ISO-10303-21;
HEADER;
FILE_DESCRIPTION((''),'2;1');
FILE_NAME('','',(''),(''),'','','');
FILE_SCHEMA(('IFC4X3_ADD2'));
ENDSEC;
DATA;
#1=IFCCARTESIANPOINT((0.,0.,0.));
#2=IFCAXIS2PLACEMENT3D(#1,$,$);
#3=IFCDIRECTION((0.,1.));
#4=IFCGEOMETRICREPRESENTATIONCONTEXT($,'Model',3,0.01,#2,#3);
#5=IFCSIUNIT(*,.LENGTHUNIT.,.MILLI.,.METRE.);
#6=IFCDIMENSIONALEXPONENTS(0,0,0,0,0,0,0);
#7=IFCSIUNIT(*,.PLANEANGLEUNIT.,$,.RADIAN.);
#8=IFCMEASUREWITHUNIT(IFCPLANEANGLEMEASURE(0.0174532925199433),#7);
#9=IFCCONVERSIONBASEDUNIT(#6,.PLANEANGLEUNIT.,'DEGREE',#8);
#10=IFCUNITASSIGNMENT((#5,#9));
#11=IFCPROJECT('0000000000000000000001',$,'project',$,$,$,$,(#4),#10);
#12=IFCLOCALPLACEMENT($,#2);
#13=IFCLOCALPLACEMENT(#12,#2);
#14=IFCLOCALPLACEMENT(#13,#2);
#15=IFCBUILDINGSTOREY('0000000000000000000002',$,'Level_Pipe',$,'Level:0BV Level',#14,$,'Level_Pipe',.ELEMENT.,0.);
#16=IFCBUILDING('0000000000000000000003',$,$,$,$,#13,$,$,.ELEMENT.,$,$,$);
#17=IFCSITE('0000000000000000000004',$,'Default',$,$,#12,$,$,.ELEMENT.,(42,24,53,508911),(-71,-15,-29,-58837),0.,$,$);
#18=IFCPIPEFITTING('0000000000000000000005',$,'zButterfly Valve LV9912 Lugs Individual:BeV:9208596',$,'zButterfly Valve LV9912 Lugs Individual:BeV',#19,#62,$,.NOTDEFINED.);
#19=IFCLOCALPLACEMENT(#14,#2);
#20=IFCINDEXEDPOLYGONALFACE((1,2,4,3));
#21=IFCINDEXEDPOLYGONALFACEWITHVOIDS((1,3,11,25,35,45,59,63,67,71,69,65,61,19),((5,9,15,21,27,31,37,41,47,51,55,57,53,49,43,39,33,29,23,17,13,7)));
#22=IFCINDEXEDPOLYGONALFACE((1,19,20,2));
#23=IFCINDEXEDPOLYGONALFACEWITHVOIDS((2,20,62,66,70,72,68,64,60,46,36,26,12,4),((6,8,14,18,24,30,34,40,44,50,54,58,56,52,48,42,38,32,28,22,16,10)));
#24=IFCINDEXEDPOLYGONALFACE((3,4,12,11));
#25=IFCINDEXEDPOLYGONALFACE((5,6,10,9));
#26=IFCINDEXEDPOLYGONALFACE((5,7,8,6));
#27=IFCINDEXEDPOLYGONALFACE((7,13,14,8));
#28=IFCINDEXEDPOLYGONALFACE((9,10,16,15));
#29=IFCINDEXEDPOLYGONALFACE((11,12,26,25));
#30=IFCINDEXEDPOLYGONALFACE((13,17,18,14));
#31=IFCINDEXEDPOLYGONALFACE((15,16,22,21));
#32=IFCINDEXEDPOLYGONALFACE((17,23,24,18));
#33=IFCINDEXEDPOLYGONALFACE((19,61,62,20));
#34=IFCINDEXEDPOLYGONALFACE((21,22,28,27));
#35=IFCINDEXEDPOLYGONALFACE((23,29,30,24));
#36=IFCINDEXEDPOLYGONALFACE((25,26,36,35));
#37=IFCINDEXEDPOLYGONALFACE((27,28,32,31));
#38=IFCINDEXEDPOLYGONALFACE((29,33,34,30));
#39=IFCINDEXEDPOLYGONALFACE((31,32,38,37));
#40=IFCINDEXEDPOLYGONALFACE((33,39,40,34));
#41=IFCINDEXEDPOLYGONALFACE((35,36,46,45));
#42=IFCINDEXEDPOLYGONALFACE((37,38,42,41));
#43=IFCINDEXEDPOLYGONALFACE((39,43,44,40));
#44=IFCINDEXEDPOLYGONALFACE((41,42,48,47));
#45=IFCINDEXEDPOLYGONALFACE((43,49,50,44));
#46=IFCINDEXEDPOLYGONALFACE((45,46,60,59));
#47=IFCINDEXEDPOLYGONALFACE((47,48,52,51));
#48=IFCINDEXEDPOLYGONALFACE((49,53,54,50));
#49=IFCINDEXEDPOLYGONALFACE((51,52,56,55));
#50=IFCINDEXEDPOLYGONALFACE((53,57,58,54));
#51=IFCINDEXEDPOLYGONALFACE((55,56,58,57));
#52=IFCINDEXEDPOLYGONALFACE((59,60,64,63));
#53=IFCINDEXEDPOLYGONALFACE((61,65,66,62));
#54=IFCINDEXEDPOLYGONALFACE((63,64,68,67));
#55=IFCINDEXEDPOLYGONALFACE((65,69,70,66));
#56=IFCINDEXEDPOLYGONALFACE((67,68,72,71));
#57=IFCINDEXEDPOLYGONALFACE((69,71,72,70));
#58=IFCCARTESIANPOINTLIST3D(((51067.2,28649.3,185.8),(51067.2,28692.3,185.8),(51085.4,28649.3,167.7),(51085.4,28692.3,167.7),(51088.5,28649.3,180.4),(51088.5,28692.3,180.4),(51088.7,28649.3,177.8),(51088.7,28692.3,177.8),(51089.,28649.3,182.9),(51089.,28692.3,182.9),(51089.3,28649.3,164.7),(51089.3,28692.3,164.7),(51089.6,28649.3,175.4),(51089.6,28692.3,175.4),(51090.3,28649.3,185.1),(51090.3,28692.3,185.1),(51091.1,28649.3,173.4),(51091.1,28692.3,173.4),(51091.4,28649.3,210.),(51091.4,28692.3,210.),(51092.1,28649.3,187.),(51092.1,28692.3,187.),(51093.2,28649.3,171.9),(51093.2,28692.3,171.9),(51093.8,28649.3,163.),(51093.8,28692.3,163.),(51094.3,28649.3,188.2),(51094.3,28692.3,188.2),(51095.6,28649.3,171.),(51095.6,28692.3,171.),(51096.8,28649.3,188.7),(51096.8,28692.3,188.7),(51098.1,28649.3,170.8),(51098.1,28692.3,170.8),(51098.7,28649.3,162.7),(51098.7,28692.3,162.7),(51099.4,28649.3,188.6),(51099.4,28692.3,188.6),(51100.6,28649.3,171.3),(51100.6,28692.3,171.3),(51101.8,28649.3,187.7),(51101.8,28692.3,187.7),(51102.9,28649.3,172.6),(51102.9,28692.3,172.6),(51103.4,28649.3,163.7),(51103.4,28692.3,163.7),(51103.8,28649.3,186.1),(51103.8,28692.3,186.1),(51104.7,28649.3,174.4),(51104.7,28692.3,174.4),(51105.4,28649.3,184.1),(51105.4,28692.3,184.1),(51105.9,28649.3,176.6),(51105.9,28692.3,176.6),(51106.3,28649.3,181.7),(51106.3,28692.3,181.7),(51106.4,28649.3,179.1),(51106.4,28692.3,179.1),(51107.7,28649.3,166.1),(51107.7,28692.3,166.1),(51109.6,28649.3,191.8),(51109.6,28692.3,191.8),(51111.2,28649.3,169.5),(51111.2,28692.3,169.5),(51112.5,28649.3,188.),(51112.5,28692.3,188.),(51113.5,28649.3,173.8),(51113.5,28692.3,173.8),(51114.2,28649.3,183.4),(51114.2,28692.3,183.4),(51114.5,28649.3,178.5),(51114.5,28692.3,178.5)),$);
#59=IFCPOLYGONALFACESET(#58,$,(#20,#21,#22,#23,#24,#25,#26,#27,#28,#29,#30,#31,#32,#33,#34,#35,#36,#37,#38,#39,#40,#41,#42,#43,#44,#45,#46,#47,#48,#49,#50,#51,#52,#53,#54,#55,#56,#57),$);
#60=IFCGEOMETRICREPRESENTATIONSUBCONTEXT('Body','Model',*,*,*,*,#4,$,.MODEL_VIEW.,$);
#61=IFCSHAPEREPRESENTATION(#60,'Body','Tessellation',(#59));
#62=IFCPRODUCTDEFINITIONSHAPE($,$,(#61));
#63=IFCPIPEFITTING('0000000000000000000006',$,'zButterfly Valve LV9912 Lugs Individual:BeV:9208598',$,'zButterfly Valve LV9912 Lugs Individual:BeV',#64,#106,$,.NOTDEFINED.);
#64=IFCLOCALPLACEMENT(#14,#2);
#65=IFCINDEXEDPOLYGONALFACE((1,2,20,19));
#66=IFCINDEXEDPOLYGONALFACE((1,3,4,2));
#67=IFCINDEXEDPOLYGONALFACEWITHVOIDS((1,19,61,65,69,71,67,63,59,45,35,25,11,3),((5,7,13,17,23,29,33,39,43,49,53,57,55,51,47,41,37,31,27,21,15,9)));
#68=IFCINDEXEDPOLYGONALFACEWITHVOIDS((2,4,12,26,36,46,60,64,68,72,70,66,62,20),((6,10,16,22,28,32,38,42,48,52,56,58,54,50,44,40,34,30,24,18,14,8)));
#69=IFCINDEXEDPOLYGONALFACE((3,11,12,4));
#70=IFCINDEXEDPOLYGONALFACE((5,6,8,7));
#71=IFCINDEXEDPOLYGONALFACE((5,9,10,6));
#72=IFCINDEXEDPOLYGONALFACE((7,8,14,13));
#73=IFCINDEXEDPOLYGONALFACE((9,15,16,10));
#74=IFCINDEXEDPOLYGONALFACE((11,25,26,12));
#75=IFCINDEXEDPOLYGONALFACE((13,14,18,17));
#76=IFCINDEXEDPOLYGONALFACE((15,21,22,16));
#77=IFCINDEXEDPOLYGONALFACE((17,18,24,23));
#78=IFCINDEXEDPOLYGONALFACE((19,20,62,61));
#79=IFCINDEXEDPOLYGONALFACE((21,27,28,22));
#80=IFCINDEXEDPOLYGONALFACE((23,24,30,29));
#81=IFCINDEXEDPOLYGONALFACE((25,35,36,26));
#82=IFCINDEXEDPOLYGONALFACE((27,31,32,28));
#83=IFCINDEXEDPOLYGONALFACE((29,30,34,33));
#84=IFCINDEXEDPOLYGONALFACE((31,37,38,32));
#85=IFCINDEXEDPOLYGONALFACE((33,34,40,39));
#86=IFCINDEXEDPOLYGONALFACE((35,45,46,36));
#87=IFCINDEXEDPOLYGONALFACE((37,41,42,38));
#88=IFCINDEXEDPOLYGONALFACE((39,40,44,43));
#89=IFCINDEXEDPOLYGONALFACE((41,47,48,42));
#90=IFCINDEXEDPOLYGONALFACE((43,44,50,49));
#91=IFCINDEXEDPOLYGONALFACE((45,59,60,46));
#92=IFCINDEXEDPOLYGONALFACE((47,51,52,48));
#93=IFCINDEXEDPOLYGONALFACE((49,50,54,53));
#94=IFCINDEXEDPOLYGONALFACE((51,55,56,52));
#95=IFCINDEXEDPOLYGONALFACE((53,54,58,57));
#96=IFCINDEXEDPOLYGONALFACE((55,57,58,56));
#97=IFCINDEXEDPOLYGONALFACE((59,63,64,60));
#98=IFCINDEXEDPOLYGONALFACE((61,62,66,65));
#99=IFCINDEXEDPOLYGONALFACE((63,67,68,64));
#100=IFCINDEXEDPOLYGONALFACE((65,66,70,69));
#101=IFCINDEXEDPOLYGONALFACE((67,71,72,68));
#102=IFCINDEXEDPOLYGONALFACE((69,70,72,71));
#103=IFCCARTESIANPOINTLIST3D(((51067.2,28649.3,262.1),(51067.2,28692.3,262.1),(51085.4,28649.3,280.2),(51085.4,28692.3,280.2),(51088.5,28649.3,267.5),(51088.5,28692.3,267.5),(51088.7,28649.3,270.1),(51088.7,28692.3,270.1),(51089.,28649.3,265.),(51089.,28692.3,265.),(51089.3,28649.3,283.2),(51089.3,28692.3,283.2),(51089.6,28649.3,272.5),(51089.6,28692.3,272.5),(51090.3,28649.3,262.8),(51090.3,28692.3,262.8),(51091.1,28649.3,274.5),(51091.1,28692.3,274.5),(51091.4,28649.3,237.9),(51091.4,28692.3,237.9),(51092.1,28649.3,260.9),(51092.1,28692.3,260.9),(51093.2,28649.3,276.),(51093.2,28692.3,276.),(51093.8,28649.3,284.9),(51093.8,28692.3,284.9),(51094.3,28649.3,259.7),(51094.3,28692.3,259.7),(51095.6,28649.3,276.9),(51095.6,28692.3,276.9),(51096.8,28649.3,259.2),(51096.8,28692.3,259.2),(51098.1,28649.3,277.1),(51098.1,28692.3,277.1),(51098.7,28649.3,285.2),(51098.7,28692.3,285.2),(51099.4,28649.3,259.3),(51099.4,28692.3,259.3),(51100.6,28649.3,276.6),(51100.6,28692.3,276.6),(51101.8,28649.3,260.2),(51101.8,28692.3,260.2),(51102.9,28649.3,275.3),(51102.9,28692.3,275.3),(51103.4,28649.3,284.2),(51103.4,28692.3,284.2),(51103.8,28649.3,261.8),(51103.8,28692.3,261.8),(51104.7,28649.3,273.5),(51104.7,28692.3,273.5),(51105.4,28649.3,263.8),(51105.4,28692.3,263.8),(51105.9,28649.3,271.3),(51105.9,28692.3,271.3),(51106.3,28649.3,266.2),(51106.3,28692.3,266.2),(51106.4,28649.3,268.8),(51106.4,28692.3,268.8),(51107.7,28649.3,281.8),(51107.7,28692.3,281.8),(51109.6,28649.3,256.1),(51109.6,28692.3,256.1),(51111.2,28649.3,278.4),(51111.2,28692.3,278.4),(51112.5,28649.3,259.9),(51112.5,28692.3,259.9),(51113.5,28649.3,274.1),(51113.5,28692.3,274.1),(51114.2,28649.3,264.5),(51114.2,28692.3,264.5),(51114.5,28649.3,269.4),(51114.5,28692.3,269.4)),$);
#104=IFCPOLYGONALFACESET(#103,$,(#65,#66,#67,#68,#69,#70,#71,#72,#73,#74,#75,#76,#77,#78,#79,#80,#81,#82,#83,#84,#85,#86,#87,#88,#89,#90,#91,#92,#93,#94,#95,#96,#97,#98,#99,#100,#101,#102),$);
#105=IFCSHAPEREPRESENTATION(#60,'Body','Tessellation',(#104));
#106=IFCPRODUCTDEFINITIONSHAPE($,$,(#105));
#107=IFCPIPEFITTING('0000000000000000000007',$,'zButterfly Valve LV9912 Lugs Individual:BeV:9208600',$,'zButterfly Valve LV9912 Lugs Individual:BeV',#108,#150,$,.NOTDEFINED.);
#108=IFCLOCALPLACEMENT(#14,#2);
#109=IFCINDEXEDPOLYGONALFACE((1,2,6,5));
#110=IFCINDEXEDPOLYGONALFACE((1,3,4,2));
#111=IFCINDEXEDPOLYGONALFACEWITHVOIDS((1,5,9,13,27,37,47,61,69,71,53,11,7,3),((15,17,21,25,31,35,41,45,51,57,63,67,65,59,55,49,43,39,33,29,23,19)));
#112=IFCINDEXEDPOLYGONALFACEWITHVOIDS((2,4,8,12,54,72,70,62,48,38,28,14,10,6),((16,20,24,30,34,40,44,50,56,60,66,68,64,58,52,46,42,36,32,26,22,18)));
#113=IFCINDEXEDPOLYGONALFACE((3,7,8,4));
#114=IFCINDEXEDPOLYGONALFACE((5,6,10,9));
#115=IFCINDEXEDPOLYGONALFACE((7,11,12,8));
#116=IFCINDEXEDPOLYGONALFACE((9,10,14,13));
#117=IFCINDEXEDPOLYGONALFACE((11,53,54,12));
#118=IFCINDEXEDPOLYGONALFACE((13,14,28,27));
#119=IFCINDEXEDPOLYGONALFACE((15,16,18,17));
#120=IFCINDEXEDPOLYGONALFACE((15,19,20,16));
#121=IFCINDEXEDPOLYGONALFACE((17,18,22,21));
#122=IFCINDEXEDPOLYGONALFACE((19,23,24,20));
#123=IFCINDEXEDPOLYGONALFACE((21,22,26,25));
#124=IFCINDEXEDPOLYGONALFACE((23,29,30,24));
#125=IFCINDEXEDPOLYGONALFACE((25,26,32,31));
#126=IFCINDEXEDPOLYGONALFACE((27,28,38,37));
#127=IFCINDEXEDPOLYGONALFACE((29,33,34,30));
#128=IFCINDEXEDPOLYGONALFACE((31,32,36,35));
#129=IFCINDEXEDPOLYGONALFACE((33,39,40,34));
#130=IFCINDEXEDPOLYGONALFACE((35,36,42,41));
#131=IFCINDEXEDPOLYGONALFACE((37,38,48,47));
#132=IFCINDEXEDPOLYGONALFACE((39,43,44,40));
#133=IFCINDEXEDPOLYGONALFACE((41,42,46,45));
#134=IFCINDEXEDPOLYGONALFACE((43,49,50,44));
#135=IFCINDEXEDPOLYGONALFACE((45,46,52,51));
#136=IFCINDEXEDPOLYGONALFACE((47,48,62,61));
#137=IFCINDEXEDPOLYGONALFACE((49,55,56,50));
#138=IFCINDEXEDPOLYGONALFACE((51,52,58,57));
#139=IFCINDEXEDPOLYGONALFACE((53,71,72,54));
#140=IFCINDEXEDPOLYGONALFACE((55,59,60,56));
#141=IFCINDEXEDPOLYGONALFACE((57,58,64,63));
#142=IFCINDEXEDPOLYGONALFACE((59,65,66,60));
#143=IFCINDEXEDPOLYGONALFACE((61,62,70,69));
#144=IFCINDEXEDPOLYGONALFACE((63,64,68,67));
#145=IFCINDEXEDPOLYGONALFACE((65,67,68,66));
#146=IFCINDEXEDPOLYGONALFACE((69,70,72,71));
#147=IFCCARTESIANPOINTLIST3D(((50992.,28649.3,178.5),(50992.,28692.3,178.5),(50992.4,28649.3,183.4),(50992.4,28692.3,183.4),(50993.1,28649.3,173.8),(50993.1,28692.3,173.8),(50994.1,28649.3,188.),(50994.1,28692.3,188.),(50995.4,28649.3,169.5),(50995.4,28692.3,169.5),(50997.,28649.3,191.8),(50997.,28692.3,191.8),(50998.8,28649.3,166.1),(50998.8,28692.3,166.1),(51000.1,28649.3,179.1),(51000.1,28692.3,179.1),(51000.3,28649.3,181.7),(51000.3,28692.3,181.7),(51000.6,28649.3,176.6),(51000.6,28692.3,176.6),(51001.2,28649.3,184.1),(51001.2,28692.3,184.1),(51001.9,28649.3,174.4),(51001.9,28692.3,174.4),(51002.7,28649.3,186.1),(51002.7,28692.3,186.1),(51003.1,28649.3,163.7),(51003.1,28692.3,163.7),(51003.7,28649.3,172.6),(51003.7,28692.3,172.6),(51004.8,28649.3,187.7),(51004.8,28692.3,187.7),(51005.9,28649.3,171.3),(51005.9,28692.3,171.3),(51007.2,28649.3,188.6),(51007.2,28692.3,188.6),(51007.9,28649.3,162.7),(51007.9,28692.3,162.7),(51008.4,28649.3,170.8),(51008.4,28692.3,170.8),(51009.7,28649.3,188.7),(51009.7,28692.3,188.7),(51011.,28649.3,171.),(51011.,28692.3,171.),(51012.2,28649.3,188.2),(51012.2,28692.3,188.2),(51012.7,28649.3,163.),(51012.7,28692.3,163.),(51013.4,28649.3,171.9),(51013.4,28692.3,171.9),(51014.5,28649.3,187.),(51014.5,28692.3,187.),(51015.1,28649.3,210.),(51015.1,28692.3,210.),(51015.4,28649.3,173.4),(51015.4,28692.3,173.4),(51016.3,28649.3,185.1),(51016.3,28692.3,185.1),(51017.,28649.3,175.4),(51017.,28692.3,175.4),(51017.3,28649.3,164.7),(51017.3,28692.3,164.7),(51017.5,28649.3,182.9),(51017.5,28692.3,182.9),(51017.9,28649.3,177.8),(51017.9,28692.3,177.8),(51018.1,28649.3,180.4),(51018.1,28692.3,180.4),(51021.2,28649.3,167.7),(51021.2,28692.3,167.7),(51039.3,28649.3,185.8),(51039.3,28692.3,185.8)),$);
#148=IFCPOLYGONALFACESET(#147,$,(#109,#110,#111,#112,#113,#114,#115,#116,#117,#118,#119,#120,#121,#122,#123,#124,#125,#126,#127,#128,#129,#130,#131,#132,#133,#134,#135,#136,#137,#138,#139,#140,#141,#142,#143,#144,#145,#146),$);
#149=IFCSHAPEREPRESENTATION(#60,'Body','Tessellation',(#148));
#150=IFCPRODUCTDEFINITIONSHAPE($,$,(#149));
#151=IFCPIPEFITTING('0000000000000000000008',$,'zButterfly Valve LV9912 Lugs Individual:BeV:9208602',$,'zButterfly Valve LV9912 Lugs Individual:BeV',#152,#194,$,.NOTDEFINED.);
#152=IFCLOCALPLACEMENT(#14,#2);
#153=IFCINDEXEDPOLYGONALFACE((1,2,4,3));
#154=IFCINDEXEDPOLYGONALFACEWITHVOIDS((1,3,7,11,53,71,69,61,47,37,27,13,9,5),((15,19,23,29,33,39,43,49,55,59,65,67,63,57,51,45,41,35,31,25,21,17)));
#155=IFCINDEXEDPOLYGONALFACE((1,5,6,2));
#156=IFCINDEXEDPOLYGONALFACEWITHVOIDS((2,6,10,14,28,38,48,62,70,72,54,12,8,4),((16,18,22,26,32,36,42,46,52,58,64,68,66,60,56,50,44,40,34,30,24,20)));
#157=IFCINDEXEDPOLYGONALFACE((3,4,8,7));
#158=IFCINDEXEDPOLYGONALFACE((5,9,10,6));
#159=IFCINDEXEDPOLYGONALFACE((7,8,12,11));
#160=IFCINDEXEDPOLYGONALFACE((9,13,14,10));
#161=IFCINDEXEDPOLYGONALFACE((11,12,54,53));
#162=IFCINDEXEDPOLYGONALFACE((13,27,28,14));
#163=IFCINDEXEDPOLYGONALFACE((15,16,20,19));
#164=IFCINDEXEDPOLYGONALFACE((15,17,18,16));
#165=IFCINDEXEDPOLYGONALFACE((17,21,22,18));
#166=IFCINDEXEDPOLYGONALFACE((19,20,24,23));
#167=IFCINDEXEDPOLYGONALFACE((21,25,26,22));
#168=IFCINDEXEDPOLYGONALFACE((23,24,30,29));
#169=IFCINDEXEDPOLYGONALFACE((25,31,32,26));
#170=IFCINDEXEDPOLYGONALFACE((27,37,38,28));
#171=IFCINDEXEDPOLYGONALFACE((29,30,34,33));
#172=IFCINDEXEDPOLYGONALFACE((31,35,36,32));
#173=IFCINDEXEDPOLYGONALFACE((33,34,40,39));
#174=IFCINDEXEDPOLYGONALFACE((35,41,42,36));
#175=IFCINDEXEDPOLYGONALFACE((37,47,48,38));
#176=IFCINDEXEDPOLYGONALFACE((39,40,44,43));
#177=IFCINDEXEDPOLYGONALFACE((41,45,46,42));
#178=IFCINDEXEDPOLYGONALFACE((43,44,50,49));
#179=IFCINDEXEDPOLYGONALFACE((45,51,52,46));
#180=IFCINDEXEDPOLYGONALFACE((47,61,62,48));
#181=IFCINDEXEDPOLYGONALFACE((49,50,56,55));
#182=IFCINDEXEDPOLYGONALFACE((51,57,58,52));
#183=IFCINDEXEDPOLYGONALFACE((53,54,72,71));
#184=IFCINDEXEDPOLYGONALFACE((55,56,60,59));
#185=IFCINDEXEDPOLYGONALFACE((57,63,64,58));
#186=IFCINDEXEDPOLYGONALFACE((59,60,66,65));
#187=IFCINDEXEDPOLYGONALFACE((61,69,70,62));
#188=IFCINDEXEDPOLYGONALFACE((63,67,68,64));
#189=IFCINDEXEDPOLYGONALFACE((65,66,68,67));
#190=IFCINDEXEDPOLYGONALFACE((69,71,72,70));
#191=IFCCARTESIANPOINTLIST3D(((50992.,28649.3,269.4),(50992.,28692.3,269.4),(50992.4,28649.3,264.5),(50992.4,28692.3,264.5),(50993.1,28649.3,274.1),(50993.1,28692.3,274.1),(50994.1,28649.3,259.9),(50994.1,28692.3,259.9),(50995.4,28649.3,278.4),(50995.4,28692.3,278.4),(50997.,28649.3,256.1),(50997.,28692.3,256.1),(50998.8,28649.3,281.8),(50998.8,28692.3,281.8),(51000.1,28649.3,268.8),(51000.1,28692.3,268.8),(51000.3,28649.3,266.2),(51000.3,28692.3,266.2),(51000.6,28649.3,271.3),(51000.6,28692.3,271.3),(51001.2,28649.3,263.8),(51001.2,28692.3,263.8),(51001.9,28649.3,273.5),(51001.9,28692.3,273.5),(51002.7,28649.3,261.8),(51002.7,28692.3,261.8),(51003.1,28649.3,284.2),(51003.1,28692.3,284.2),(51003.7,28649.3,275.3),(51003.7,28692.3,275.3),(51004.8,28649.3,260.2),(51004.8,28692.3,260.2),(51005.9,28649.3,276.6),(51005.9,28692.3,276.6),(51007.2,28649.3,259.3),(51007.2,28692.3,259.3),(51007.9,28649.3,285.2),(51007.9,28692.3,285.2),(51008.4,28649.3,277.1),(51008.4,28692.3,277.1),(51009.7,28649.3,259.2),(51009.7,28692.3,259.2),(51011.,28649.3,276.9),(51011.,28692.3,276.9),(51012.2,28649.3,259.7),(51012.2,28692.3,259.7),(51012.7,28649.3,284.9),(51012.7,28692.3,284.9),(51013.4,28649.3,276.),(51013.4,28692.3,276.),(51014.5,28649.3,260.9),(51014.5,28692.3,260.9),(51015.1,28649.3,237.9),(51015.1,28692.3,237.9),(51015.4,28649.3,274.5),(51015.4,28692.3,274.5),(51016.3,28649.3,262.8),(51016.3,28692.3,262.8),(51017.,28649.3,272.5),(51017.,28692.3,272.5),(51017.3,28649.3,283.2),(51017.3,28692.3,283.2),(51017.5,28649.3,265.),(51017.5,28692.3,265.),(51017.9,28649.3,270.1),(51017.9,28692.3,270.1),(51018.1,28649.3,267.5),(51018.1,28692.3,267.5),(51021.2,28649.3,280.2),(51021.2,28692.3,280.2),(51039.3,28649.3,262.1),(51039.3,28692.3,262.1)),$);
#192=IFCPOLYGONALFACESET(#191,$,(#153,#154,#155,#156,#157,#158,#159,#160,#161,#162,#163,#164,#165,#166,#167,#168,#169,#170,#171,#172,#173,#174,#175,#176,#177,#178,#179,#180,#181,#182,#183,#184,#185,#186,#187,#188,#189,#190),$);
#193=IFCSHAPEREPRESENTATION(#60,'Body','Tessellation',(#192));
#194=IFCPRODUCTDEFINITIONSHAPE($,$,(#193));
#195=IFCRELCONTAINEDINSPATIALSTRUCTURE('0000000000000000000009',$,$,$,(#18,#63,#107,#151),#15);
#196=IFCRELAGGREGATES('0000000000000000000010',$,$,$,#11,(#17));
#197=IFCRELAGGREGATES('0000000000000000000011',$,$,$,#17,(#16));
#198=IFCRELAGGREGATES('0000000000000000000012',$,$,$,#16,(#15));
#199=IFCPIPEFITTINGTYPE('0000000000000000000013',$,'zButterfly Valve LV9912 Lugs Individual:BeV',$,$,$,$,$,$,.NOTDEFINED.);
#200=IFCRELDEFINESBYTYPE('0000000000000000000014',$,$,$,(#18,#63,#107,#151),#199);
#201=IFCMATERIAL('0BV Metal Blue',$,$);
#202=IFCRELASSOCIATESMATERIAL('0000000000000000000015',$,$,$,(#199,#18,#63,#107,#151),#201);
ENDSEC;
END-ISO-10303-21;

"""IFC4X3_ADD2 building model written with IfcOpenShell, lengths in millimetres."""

from ifc_helpers import new_model, entity, si_unit, converted_unit, direction, frame, frame_2d, origin, place, context, subcontext, project, spatial, polyline, circle_curve, parameter, trimmed, segment, composite_curve, outline, extrude, source, transform, mapped, material, type_object, type_shapes, element, save


model = new_model("IFC4X3_ADD2")

# Units and contexts
model_context = context("Model", 3, precision=0.01, world=origin(), true_north=direction((0.0, 1.0)))
body_context = subcontext(model_context, "Body", "Model", "MODEL_VIEW")
ifc_project = project(units=[si_unit("LENGTHUNIT", "METRE", prefix="MILLI"), converted_unit("PLANEANGLEUNIT", "DEGREE", entity("IfcPlaneAngleMeasure", 0.0174532925199433), si_unit("PLANEANGLEUNIT", "RADIAN"), dimensions=[0, 0, 0, 0, 0, 0, 0])], contexts=[model_context])

# Site, building, storey
site_placement = place(None, origin())
site = spatial("IfcSite", under=ifc_project, at=site_placement, Name="Default", CompositionType="ELEMENT", RefLatitude=(42, 24, 53, 508911), RefLongitude=(-71, -15, -29, -58837), RefElevation=0.0)
building_placement = place(site_placement, origin())
building = spatial("IfcBuilding", under=site, at=building_placement, CompositionType="ELEMENT")
storey_placement = place(building_placement, origin())
storey = spatial("IfcBuildingStorey", under=building, at=storey_placement, Name="Level_Pipe", ObjectType="Level:0BV Level", LongName="Level_Pipe", CompositionType="ELEMENT", Elevation=0.0)

# Pipe fittings
ifc_material_1 = material(Name="0BV Metal Blue")
pipe_fitting_type_1 = type_object("IfcPipeFittingType", Name="zButterfly Valve LV9912 Lugs Individual:BeV", PredefinedType="NOTDEFINED", material=ifc_material_1)
shared_shape_1 = source(origin(), body_context, "Body", "SweptSolid", [
    extrude(outline(composite_curve([segment(polyline([(-17.1, -12.8), (17.1, -12.8)]), True, "CONTINUOUS"), segment(polyline([(17.1, -12.8), (17.1, 12.8)]), True, "CONTINUOUS"), segment(trimmed(circle_curve(frame_2d((0.0, 12.8), x_axis=(1.0, 0.0)), 17.1), [parameter(360.0)], [parameter(180.0)], True, "PARAMETER"), True, "CONTINUOUS"), segment(polyline([(-17.1, 12.8), (-17.1, -12.8)]), True, "CONTINUOUS")], self_intersect=False), holes=[composite_curve([segment(trimmed(circle_curve(frame_2d((0.0, 12.8), x_axis=(1.0, 0.0)), 9.0), [parameter(0.0)], [parameter(180.0)], True, "PARAMETER"), False, "CONTINUOUS"), segment(trimmed(circle_curve(frame_2d((0.0, 12.8), x_axis=(1.0, 0.0)), 9.0), [parameter(180.0)], [parameter(0.0)], True, "PARAMETER"), False, "CONTINUOUS")], self_intersect=False)]), frame((0.0, -12.8, -21.5)), (0.0, 0.0, 1.0), 43.0),
])
type_shapes(pipe_fitting_type_1, [shared_shape_1])
for number, where, z_axis, x_axis, name in (
    (1, (51097.5, 28670.8, 179.8), (0.0, -1.0, 0.0), (-0.707107, 0.0, -0.707107), "zButterfly Valve LV9912 Lugs Individual:BeV:9208596"),
    (2, (51097.5, 28670.8, 268.1), (0.0, -1.0, 0.0), (0.707107, 0.0, -0.707107), "zButterfly Valve LV9912 Lugs Individual:BeV:9208598"),
    (3, (51009.1, 28670.8, 179.8), (0.0, -1.0, 0.0), (-0.707107, 0.0, 0.707107), "zButterfly Valve LV9912 Lugs Individual:BeV:9208600"),
    (4, (51009.1, 28670.8, 268.1), (0.0, -1.0, 0.0), (0.707107, 0.0, 0.707107), "zButterfly Valve LV9912 Lugs Individual:BeV:9208602"),
):
    element("IfcPipeFitting", number, at=place(storey_placement, frame(where, z_axis=z_axis, x_axis=x_axis)), inside=storey, type_object=pipe_fitting_type_1, material=ifc_material_1, Name=name, ObjectType="zButterfly Valve LV9912 Lugs Individual:BeV", PredefinedType="NOTDEFINED", context=body_context, shape_type="MappedRepresentation", body=[
        mapped(shared_shape_1, transform((0.0, 0.0, 0.0), scale=1.0)),
    ])

save(model, "model.ifc")
